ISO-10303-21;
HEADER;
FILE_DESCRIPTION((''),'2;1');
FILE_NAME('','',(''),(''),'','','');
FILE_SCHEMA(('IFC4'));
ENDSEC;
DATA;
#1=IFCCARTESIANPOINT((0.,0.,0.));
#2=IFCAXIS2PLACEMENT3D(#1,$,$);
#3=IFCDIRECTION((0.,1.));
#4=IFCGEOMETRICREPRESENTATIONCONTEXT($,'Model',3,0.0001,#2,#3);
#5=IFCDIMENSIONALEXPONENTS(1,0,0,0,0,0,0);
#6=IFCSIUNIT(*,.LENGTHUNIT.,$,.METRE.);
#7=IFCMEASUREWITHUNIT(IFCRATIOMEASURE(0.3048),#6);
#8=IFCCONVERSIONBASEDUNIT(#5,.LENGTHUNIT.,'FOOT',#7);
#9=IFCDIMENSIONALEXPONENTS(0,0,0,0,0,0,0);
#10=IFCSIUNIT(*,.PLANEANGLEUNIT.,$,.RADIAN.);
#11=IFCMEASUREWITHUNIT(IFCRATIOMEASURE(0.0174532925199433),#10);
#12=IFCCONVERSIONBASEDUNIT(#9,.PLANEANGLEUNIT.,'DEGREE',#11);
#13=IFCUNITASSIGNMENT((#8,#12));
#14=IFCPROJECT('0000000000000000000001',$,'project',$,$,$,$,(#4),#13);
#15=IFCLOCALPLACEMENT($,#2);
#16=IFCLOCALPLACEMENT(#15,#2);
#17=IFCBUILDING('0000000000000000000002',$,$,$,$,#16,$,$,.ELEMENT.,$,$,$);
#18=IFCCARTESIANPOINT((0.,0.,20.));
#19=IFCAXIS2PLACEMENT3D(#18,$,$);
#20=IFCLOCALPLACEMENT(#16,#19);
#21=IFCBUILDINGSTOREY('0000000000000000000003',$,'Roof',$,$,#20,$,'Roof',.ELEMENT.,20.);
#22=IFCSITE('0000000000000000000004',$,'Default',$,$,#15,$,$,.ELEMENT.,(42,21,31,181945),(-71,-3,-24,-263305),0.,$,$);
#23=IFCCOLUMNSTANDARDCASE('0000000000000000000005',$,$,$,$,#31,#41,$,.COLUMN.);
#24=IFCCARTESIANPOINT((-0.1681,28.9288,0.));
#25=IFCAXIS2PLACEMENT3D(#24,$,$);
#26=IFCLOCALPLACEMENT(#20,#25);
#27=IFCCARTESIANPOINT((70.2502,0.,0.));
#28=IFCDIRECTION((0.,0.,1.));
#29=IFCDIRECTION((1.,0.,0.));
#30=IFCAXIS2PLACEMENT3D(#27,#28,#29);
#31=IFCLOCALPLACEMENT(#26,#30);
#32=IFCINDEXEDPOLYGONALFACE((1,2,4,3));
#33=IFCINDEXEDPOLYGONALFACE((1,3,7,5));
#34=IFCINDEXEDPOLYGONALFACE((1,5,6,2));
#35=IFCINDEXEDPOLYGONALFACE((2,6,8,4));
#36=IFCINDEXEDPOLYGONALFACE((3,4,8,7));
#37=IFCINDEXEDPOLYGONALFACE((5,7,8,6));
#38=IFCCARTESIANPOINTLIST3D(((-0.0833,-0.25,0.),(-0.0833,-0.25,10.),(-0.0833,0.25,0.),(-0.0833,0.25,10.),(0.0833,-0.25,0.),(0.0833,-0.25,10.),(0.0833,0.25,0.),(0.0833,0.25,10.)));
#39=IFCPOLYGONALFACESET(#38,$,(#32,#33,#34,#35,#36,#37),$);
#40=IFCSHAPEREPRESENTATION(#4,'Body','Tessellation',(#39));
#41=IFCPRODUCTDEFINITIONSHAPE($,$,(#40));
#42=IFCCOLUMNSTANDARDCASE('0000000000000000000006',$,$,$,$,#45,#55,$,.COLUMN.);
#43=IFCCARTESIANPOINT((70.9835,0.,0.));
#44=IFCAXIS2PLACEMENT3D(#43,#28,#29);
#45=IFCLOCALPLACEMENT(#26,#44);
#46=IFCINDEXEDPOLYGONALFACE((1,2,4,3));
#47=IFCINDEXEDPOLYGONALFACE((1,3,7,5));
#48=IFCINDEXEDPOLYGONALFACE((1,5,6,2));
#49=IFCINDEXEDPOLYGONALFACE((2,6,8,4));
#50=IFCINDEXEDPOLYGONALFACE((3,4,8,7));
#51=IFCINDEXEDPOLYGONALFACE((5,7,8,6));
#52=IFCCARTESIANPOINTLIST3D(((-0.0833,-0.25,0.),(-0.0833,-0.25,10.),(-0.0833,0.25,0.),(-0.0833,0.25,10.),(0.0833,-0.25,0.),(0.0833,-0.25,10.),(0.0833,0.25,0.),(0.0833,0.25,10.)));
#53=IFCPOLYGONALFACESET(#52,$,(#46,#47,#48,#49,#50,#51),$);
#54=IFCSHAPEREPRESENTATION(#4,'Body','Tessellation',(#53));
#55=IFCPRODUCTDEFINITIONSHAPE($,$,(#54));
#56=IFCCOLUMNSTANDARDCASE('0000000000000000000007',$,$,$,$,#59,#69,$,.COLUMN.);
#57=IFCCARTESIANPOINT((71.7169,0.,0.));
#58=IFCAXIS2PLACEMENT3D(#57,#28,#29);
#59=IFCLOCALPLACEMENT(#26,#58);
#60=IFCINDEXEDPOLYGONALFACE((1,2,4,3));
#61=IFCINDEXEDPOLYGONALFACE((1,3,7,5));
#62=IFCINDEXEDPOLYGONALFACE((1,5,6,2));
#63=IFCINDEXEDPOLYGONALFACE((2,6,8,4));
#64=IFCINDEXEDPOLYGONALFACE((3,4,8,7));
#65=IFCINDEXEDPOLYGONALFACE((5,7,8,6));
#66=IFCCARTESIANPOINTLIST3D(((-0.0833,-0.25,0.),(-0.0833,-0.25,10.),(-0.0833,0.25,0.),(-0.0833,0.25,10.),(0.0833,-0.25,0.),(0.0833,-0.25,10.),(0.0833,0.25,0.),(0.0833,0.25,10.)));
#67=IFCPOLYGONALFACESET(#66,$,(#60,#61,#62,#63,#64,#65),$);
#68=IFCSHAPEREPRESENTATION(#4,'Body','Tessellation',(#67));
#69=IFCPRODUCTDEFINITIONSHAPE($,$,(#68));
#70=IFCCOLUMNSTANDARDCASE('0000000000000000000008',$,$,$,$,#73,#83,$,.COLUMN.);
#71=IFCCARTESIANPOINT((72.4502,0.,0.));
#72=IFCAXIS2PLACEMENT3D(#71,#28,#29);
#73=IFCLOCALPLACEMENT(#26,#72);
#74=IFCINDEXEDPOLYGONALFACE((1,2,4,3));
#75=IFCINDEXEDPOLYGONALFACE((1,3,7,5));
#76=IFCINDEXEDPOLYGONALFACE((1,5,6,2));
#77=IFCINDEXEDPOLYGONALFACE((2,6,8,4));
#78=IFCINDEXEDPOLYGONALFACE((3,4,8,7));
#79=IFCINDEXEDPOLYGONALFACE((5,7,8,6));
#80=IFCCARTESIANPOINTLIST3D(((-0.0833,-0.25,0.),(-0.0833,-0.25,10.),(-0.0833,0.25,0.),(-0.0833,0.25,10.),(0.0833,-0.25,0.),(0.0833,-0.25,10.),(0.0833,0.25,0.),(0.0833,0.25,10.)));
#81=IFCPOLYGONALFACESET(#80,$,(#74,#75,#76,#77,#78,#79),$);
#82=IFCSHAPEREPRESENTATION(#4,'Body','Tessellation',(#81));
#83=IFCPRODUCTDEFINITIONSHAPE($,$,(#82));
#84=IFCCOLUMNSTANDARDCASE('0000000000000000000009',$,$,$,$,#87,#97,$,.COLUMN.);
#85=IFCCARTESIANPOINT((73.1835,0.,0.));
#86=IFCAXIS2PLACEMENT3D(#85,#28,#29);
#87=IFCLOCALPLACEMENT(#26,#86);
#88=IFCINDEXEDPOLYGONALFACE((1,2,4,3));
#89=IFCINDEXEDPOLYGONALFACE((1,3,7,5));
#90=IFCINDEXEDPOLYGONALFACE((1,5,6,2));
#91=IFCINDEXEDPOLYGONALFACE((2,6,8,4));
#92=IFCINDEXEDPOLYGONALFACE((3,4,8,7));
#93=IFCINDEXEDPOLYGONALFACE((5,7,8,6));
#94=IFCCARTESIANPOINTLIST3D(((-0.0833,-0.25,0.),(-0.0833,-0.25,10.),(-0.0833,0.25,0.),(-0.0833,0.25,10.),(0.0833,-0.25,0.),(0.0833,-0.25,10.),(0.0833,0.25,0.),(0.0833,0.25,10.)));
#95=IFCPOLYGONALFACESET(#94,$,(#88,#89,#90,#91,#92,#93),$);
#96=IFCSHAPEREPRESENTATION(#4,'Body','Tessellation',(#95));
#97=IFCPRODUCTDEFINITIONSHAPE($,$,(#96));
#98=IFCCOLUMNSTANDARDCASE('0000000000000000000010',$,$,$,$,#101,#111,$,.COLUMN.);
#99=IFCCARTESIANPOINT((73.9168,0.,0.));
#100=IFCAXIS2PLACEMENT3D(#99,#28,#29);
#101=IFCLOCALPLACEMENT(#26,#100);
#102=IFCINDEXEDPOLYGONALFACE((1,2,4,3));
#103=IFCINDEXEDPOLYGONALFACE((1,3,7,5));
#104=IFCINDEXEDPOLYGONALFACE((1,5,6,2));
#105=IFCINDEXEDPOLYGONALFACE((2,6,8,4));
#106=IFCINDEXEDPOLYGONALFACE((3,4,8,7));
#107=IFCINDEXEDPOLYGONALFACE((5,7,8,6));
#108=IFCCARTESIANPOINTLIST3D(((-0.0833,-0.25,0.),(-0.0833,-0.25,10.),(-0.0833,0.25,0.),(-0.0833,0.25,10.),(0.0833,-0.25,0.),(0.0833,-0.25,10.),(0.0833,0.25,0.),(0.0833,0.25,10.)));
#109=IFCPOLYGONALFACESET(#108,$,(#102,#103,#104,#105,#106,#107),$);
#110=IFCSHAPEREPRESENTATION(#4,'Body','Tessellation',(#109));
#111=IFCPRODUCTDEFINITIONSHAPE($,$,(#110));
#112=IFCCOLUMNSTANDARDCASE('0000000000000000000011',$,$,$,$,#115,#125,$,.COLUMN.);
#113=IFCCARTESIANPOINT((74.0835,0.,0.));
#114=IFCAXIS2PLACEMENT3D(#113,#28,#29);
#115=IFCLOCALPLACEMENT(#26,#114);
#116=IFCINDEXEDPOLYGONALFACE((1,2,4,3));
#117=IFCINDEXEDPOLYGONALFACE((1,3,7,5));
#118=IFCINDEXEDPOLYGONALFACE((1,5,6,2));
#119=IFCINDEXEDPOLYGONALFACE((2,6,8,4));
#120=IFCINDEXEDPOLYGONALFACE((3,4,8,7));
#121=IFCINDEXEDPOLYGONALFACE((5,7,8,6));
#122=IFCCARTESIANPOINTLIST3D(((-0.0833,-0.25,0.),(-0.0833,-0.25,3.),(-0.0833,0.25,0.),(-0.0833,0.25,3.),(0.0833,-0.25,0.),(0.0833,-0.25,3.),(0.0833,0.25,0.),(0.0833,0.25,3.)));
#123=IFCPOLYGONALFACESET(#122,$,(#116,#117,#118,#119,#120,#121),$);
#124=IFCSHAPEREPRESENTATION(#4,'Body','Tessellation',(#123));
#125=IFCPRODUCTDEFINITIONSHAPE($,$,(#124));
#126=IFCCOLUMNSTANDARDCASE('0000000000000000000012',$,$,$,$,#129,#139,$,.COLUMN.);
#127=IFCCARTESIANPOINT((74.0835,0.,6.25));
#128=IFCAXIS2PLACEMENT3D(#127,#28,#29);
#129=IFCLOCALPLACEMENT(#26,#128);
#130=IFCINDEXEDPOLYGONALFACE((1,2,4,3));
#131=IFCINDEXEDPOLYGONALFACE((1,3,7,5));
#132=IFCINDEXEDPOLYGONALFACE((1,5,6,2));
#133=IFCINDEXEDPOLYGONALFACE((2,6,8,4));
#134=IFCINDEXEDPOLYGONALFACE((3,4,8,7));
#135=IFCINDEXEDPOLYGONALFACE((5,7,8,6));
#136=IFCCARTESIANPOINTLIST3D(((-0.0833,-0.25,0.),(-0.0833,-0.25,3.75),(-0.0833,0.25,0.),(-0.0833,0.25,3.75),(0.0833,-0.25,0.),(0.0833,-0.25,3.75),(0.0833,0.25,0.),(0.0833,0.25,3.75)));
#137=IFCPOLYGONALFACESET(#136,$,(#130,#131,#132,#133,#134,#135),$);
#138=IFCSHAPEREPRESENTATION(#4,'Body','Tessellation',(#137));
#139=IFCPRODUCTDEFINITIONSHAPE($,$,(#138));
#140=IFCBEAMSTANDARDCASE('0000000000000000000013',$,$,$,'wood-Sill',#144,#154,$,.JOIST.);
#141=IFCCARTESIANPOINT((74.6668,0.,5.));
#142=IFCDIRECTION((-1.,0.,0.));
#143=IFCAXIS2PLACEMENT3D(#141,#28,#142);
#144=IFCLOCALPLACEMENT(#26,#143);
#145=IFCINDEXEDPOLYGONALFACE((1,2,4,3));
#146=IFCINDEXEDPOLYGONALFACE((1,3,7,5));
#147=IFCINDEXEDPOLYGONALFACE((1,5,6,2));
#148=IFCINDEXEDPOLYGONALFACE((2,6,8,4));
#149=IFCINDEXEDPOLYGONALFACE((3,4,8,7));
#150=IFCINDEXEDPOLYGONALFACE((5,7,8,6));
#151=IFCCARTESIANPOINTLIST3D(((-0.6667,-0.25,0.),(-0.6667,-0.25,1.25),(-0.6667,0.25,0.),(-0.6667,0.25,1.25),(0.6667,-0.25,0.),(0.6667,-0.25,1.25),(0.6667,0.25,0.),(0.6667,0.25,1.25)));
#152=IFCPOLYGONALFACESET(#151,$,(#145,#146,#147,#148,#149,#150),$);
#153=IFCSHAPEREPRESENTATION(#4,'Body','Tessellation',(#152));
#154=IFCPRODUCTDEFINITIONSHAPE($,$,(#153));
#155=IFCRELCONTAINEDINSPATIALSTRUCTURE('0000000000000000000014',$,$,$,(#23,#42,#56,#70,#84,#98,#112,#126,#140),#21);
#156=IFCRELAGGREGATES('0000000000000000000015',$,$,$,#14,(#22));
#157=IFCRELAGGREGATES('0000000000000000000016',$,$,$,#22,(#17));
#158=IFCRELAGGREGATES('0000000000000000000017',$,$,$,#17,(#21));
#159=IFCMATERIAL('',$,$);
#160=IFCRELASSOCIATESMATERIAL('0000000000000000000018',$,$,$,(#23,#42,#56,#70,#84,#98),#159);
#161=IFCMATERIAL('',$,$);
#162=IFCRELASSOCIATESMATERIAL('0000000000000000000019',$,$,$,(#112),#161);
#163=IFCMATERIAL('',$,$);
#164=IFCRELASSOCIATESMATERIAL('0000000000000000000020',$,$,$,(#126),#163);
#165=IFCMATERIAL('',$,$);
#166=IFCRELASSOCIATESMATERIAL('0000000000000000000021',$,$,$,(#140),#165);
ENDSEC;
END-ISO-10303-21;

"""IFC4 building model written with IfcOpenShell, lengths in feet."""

from ifc_helpers import new_model, entity, si_unit, converted_unit, direction, frame, origin, place, context, project, spatial, rectangle, extrude, material, element, save


model = new_model("IFC4")

# Units and contexts
model_context = context("Model", 3, precision=0.0001, world=origin(), true_north=direction((0.0, 1.0)))
ifc_project = project(units=[converted_unit("LENGTHUNIT", "FOOT", entity("IfcRatioMeasure", 0.3048), si_unit("LENGTHUNIT", "METRE"), dimensions=[1, 0, 0, 0, 0, 0, 0]), converted_unit("PLANEANGLEUNIT", "DEGREE", entity("IfcRatioMeasure", 0.0174532925199433), si_unit("PLANEANGLEUNIT", "RADIAN"), dimensions=[0, 0, 0, 0, 0, 0, 0])], contexts=[model_context])

# Site, building, storey
site_placement = place(None, origin())
site = spatial("IfcSite", under=ifc_project, at=site_placement, Name="Default", CompositionType="ELEMENT", RefLatitude=(42, 21, 31, 181945), RefLongitude=(-71, -3, -24, -263305), RefElevation=0.0)
building_placement = place(site_placement, origin())
building = spatial("IfcBuilding", under=site, at=building_placement, CompositionType="ELEMENT")
storey_placement = place(building_placement, frame((0.0, 0.0, 20.0)))
storey = spatial("IfcBuildingStorey", under=building, at=storey_placement, Name="Roof", LongName="Roof", CompositionType="ELEMENT", Elevation=20.0)

# Columns
ifc_material_1 = material(Name="")
placement_1 = place(storey_placement, frame((-0.1681, 28.9288, 0.0)))
for number, where, z_axis, x_axis in (
    (1, (70.2502, 0.0, 0.0), (0.0, 0.0, 1.0), (1.0, 0.0, 0.0)),
    (2, (70.9835, 0.0, 0.0), (0.0, 0.0, 1.0), (1.0, 0.0, 0.0)),
    (3, (71.7169, 0.0, 0.0), (0.0, 0.0, 1.0), (1.0, 0.0, 0.0)),
    (4, (72.4502, 0.0, 0.0), (0.0, 0.0, 1.0), (1.0, 0.0, 0.0)),
    (5, (73.1835, 0.0, 0.0), (0.0, 0.0, 1.0), (1.0, 0.0, 0.0)),
    (6, (73.9168, 0.0, 0.0), (0.0, 0.0, 1.0), (1.0, 0.0, 0.0)),
):
    element("IfcColumnStandardCase", number, at=place(placement_1, frame(where, z_axis=z_axis, x_axis=x_axis)), inside=storey, material=ifc_material_1, PredefinedType="COLUMN", context=model_context, shape_type="SweptSolid", body=[
        extrude(rectangle(XDim=0.1667, YDim=0.5), origin(), (0.0, 0.0, 1.0), 10.0),
    ])
ifc_material_2 = material(Name="")
for number, where, z_axis, x_axis in (
    (7, (74.0835, 0.0, 0.0), (0.0, 0.0, 1.0), (1.0, 0.0, 0.0)),
):
    element("IfcColumnStandardCase", number, at=place(placement_1, frame(where, z_axis=z_axis, x_axis=x_axis)), inside=storey, material=ifc_material_2, PredefinedType="COLUMN", context=model_context, shape_type="SweptSolid", body=[
        extrude(rectangle(XDim=0.1667, YDim=0.5), origin(), (0.0, 0.0, 1.0), 3.0),
    ])
ifc_material_3 = material(Name="")
for number, where, z_axis, x_axis in (
    (8, (74.0835, 0.0, 6.25), (0.0, 0.0, 1.0), (1.0, 0.0, 0.0)),
):
    element("IfcColumnStandardCase", number, at=place(placement_1, frame(where, z_axis=z_axis, x_axis=x_axis)), inside=storey, material=ifc_material_3, PredefinedType="COLUMN", context=model_context, shape_type="SweptSolid", body=[
        extrude(rectangle(XDim=0.1667, YDim=0.5), origin(), (0.0, 0.0, 1.0), 3.75),
    ])

# Beam
ifc_material_4 = material(Name="")
for number, where, z_axis, x_axis in (
    (9, (74.6668, 0.0, 5.0), (0.0, 0.0, 1.0), (-1.0, 0.0, 0.0)),
):
    element("IfcBeamStandardCase", number, at=place(placement_1, frame(where, z_axis=z_axis, x_axis=x_axis)), inside=storey, material=ifc_material_4, ObjectType="wood-Sill", PredefinedType="JOIST", context=model_context, shape_type="SweptSolid", body=[
        extrude(rectangle(XDim=1.3333, YDim=0.5), origin(), (0.0, 0.0, 1.0), 1.25),
    ])

save(model, "model.ifc")
